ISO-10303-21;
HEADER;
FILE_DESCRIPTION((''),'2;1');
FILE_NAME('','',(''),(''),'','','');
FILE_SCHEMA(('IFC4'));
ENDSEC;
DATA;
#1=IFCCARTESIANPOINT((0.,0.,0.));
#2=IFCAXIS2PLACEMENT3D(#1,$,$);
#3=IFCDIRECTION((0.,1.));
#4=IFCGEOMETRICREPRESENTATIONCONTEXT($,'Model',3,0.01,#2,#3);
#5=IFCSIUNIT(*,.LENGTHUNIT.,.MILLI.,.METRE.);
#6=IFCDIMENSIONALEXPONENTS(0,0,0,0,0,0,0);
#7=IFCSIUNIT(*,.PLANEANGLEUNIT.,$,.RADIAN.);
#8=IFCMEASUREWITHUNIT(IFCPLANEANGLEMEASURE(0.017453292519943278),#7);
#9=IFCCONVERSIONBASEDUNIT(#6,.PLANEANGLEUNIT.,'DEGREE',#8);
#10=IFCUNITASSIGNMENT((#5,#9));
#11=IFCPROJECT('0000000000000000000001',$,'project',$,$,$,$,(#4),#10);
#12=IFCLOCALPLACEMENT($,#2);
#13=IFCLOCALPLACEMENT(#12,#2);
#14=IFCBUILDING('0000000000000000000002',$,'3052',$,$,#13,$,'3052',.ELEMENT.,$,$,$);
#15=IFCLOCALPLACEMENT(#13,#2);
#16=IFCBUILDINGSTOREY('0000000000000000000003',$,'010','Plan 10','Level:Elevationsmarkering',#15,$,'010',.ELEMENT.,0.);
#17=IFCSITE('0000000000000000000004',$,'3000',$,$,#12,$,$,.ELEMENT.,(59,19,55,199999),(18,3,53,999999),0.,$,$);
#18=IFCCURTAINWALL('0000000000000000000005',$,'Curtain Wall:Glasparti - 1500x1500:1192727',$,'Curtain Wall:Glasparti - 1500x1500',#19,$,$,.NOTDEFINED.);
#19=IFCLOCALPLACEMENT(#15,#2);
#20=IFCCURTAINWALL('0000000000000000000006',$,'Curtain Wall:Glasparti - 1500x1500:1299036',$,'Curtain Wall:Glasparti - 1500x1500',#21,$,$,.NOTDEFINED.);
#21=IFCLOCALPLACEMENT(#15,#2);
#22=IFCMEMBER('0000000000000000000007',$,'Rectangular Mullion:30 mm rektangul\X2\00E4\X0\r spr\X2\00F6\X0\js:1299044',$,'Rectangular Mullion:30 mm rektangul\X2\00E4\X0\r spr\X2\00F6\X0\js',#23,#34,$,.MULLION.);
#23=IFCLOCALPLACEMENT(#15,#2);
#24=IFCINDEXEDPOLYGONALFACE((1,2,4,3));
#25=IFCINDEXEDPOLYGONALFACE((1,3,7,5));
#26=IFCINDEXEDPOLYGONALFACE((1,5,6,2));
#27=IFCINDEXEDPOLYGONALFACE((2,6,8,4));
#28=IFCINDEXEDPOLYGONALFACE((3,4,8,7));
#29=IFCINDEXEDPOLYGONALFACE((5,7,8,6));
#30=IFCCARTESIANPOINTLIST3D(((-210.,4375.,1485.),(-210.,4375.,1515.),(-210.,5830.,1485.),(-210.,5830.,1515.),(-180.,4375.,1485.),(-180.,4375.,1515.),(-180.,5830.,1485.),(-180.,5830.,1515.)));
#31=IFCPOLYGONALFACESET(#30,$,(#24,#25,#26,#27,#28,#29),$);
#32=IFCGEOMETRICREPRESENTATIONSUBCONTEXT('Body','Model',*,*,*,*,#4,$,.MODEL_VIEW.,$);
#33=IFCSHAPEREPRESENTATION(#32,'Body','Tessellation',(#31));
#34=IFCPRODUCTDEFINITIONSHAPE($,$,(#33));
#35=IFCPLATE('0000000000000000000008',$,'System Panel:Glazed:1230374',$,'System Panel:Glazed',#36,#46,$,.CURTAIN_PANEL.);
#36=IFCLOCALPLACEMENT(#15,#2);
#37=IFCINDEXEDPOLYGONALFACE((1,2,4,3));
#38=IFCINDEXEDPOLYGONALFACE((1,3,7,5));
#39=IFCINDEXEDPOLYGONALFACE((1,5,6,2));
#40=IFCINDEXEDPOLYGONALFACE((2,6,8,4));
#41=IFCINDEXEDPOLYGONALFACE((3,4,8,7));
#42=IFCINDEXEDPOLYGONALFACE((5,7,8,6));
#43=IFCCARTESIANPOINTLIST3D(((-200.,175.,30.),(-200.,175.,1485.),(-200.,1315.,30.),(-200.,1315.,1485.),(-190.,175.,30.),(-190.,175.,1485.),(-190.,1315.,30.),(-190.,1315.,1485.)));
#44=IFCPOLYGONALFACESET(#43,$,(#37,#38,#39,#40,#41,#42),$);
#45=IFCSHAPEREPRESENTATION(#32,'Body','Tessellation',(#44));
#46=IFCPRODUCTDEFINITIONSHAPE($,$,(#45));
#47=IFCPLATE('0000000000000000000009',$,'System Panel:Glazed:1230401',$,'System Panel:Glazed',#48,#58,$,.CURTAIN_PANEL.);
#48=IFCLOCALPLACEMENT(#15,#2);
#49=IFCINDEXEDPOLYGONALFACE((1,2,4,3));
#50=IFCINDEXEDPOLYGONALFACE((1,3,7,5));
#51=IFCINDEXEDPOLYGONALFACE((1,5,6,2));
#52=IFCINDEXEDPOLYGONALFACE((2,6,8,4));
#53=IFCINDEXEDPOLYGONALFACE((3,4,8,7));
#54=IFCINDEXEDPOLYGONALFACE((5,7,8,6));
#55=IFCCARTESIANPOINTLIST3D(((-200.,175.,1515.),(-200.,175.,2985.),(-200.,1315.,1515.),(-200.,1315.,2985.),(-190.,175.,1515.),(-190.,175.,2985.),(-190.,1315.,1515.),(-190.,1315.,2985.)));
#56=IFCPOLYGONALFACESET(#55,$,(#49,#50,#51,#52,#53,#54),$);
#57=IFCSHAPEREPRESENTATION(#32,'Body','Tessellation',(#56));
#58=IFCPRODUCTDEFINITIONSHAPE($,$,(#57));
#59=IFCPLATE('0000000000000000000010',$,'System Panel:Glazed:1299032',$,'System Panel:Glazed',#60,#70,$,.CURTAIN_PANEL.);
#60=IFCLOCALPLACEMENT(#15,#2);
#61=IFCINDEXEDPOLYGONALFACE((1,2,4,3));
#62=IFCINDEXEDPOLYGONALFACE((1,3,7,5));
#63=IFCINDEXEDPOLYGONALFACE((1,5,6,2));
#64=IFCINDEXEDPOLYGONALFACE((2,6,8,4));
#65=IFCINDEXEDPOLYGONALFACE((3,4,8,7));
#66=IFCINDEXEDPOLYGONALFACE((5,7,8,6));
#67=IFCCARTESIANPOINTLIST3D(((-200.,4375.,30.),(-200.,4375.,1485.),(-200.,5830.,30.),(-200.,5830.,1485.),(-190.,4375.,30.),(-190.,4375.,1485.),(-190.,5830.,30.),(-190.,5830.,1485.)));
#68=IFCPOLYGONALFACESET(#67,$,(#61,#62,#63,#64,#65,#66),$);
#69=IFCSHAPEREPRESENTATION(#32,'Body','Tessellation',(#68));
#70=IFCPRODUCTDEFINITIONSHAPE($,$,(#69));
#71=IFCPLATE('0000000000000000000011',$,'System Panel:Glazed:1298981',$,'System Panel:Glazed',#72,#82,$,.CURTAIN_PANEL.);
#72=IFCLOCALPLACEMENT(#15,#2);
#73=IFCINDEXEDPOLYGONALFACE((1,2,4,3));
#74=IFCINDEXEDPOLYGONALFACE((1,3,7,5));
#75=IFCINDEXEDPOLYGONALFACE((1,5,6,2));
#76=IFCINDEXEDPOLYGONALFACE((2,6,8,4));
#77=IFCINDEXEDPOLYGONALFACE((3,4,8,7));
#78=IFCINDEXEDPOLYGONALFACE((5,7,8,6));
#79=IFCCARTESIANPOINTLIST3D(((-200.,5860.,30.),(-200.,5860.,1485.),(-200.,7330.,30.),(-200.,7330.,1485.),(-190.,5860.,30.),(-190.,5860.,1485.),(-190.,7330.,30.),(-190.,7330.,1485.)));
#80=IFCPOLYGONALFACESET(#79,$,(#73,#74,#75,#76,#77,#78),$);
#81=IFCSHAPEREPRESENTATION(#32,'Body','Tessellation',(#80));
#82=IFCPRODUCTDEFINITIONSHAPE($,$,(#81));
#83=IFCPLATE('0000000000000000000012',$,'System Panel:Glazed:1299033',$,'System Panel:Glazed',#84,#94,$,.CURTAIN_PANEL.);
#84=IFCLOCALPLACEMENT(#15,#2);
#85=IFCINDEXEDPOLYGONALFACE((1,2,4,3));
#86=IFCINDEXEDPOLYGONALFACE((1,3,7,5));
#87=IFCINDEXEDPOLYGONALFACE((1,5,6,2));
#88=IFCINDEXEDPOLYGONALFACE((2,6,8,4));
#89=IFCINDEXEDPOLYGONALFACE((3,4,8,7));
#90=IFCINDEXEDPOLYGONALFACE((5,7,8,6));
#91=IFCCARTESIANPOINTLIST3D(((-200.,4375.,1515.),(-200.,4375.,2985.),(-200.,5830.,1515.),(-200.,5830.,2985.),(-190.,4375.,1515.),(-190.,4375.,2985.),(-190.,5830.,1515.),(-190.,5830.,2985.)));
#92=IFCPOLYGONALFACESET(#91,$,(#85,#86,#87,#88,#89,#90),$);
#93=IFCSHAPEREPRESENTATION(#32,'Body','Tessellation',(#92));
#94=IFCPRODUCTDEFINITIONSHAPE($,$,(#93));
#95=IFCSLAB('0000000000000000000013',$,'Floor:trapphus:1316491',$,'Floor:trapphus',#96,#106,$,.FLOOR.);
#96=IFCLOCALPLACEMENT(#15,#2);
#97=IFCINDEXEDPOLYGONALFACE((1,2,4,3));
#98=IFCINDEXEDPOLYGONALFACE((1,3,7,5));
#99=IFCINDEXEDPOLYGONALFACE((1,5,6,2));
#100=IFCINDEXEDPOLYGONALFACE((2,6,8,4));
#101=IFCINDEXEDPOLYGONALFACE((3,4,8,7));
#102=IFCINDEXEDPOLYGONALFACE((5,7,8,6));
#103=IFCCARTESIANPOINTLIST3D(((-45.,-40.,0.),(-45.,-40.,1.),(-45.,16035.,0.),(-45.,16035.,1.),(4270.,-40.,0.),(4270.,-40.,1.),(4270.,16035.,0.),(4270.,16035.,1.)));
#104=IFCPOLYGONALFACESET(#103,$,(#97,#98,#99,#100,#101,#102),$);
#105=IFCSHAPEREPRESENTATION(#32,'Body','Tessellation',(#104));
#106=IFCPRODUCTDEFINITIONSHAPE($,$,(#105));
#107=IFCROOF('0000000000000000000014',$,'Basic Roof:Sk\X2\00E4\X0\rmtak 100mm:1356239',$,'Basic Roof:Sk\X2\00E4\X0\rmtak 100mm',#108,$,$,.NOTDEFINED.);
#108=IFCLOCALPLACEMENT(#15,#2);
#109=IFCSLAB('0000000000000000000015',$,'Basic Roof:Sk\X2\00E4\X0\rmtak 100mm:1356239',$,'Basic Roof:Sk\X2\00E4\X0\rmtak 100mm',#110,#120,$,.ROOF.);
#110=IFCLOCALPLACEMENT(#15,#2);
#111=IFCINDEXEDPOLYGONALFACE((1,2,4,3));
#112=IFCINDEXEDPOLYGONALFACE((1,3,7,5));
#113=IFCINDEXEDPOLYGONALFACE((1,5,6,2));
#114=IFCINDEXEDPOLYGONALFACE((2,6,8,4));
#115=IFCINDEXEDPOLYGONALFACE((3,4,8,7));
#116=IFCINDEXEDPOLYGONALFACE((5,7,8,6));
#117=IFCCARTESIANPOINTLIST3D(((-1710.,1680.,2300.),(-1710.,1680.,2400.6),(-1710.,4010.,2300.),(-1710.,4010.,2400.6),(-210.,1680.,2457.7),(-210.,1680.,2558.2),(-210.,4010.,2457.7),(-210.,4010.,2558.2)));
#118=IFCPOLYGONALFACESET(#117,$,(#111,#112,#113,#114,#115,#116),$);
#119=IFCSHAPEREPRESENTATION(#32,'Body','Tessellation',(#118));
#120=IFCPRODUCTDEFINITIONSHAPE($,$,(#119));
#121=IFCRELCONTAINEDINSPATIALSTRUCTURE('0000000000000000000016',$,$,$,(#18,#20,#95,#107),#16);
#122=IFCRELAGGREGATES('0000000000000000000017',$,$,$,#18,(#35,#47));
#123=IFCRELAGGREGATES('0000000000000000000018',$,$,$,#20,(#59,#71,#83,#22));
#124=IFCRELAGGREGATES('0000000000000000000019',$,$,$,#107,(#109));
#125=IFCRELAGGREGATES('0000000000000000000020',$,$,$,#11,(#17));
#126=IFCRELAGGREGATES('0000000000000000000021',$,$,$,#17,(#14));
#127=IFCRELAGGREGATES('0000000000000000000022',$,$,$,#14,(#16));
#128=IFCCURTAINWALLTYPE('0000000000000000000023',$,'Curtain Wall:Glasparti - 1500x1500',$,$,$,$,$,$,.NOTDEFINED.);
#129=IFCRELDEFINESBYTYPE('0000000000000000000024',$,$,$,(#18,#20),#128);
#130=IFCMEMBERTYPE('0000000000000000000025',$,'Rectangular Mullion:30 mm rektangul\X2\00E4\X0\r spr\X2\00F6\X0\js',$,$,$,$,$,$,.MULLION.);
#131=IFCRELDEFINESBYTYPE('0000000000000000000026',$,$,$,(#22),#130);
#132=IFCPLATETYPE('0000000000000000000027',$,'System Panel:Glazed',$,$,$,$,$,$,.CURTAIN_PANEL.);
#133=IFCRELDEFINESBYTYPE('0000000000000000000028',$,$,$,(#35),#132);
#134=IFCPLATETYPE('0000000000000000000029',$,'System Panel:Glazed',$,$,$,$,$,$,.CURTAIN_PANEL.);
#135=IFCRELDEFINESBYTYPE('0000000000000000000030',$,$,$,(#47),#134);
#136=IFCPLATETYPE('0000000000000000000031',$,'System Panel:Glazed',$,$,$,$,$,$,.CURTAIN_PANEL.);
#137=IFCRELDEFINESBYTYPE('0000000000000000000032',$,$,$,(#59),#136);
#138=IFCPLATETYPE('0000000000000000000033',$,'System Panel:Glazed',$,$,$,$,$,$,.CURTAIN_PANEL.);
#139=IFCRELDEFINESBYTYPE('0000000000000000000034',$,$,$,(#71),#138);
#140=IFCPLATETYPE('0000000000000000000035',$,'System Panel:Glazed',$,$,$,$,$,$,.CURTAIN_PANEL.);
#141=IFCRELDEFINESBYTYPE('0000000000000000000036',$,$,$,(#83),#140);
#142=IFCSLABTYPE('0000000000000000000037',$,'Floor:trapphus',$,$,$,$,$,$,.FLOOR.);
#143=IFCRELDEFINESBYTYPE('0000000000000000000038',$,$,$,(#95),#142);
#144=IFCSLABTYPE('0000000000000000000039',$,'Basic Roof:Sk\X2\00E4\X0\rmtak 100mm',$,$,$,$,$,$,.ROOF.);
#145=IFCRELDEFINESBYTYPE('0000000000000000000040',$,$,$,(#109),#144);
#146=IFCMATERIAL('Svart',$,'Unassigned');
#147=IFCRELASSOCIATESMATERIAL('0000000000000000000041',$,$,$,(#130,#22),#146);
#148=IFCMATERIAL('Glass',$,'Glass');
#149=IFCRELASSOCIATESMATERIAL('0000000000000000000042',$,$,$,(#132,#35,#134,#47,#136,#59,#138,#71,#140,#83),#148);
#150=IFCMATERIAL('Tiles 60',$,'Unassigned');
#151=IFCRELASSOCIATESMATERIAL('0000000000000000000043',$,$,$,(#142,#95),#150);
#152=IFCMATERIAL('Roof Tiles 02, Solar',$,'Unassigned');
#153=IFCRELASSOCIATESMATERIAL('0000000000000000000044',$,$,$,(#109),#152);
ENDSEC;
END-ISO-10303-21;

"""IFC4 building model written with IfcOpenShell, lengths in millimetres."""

from ifc_helpers import new_model, entity, si_unit, converted_unit, direction, frame, origin, place, context, subcontext, project, spatial, indexed_curve, outline, extrude, source, transform, mapped, material, type_object, type_shapes, element, aggregate, save


model = new_model("IFC4")

# Units and contexts
model_context = context("Model", 3, precision=0.01, world=origin(), true_north=direction((0.0, 1.0)))
body_context = subcontext(model_context, "Body", "Model", "MODEL_VIEW")
ifc_project = project(units=[si_unit("LENGTHUNIT", "METRE", prefix="MILLI"), converted_unit("PLANEANGLEUNIT", "DEGREE", entity("IfcPlaneAngleMeasure", 0.017453292519943278), si_unit("PLANEANGLEUNIT", "RADIAN"), dimensions=[0, 0, 0, 0, 0, 0, 0])], contexts=[model_context])

# Site, building, storey
site_placement = place(None, origin())
site = spatial("IfcSite", under=ifc_project, at=site_placement, Name="3000", CompositionType="ELEMENT", RefLatitude=(59, 19, 55, 199999), RefLongitude=(18, 3, 53, 999999), RefElevation=0.0)
building_placement = place(site_placement, origin())
building = spatial("IfcBuilding", under=site, at=building_placement, Name="3052", LongName="3052", CompositionType="ELEMENT")
storey_placement = place(building_placement, origin())
storey = spatial("IfcBuildingStorey", under=building, at=storey_placement, Name="010", Description="Plan 10", ObjectType="Level:Elevationsmarkering", LongName="010", CompositionType="ELEMENT", Elevation=0.0)

# Curtain wall
curtain_wall_type = type_object("IfcCurtainWallType", Name="Curtain Wall:Glasparti - 1500x1500", PredefinedType="NOTDEFINED")
curtain_wall_1_placement = place(storey_placement, origin())
curtain_wall_1 = element("IfcCurtainWall", 1, at=curtain_wall_1_placement, inside=storey, type_object=curtain_wall_type, Name="Curtain Wall:Glasparti - 1500x1500:1192727", ObjectType="Curtain Wall:Glasparti - 1500x1500", PredefinedType="NOTDEFINED")
ifc_material_1 = material(Name="Svart", Category="Unassigned")

# Curtain wall
curtain_wall_2_placement = place(storey_placement, origin())
curtain_wall_2 = element("IfcCurtainWall", 2, at=curtain_wall_2_placement, inside=storey, type_object=curtain_wall_type, Name="Curtain Wall:Glasparti - 1500x1500:1299036", ObjectType="Curtain Wall:Glasparti - 1500x1500", PredefinedType="NOTDEFINED")

# Member
member_type_1 = type_object("IfcMemberType", Name="Rectangular Mullion:30 mm rektangulär spröjs", PredefinedType="MULLION", material=ifc_material_1)
shared_shape_1 = source(origin(), body_context, "Body", "SweptSolid", [
    extrude(outline(indexed_curve([(-15.0, -15.0), (15.0, -15.0), (15.0, 15.0), (-15.0, 15.0), (-15.0, -15.0)], self_intersect=False)), frame((0.0, 0.0, -1455.0), z_axis=(0.0, 0.0, 1.0), x_axis=(-1.0, 0.0, 0.0)), (0.0, 0.0, 1.0), 1455.0),
])
type_shapes(member_type_1, [shared_shape_1])
member_1_placement = place(curtain_wall_2_placement, frame((-195.0, 5830.0, 1500.0), z_axis=(0.0, 1.0, 0.0), x_axis=(0.0, 0.0, 1.0)))
member_1 = element("IfcMember", 3, at=member_1_placement, type_object=member_type_1, material=ifc_material_1, Name="Rectangular Mullion:30 mm rektangulär spröjs:1299044", ObjectType="Rectangular Mullion:30 mm rektangulär spröjs", PredefinedType="MULLION", context=body_context, shape_type="MappedRepresentation", body=[
    mapped(shared_shape_1, transform((0.0, 0.0, 0.0), scale=1.0)),
])

# Plates
ifc_material_2 = material(Name="Glass", Category="Glass")
plate_type_1 = type_object("IfcPlateType", Name="System Panel:Glazed", PredefinedType="CURTAIN_PANEL", material=ifc_material_2)
shared_shape_2 = source(origin(), body_context, "Body", "SweptSolid", [
    extrude(outline(indexed_curve([(-5.0, -570.0), (5.0, -570.0), (5.0, 570.0), (-5.0, 570.0), (-5.0, -570.0)], self_intersect=False)), frame((0.0, 0.0, 0.0), z_axis=(0.0, 0.0, 1.0), x_axis=(0.0, 1.0, 0.0)), (0.0, 0.0, 1.0), 1455.0),
])
type_shapes(plate_type_1, [shared_shape_2])
plate_1_placement = place(curtain_wall_1_placement, frame((-195.0, 745.0, 30.0), z_axis=(0.0, 0.0, 1.0), x_axis=(0.0, 1.0, 0.0)))
plate_1 = element("IfcPlate", 4, at=plate_1_placement, type_object=plate_type_1, material=ifc_material_2, Name="System Panel:Glazed:1230374", ObjectType="System Panel:Glazed", PredefinedType="CURTAIN_PANEL", context=body_context, shape_type="MappedRepresentation", body=[
    mapped(shared_shape_2, transform((0.0, 0.0, 0.0), scale=1.0)),
])
plate_type_2 = type_object("IfcPlateType", Name="System Panel:Glazed", PredefinedType="CURTAIN_PANEL", material=ifc_material_2)
shared_shape_3 = source(origin(), body_context, "Body", "SweptSolid", [
    extrude(outline(indexed_curve([(-5.0, -570.0), (5.0, -570.0), (5.0, 570.0), (-5.0, 570.0), (-5.0, -570.0)], self_intersect=False)), frame((0.0, 0.0, 0.0), z_axis=(0.0, 0.0, 1.0), x_axis=(0.0, 1.0, 0.0)), (0.0, 0.0, 1.0), 1470.0),
])
type_shapes(plate_type_2, [shared_shape_3])
plate_2_placement = place(curtain_wall_1_placement, frame((-195.0, 745.0, 1515.0), z_axis=(0.0, 0.0, 1.0), x_axis=(0.0, 1.0, 0.0)))
plate_2 = element("IfcPlate", 5, at=plate_2_placement, type_object=plate_type_2, material=ifc_material_2, Name="System Panel:Glazed:1230401", ObjectType="System Panel:Glazed", PredefinedType="CURTAIN_PANEL", context=body_context, shape_type="MappedRepresentation", body=[
    mapped(shared_shape_3, transform((0.0, 0.0, 0.0), scale=1.0)),
])
aggregate(curtain_wall_1, [plate_1, plate_2])
plate_type_3 = type_object("IfcPlateType", Name="System Panel:Glazed", PredefinedType="CURTAIN_PANEL", material=ifc_material_2)
shared_shape_4 = source(origin(), body_context, "Body", "SweptSolid", [
    extrude(outline(indexed_curve([(-5.0, -727.5), (5.0, -727.5), (5.0, 727.5), (-5.0, 727.5), (-5.0, -727.5)], self_intersect=False)), frame((0.0, 0.0, 0.0), z_axis=(0.0, 0.0, 1.0), x_axis=(0.0, 1.0, 0.0)), (0.0, 0.0, 1.0), 1455.0),
])
type_shapes(plate_type_3, [shared_shape_4])
plate_3_placement = place(curtain_wall_2_placement, frame((-195.0, 5102.5, 30.0), z_axis=(0.0, 0.0, 1.0), x_axis=(0.0, 1.0, 0.0)))
plate_3 = element("IfcPlate", 6, at=plate_3_placement, type_object=plate_type_3, material=ifc_material_2, Name="System Panel:Glazed:1299032", ObjectType="System Panel:Glazed", PredefinedType="CURTAIN_PANEL", context=body_context, shape_type="MappedRepresentation", body=[
    mapped(shared_shape_4, transform((0.0, 0.0, 0.0), scale=1.0)),
])
plate_type_4 = type_object("IfcPlateType", Name="System Panel:Glazed", PredefinedType="CURTAIN_PANEL", material=ifc_material_2)
shared_shape_5 = source(origin(), body_context, "Body", "SweptSolid", [
    extrude(outline(indexed_curve([(-5.0, -735.0), (5.0, -735.0), (5.0, 735.0), (-5.0, 735.0), (-5.0, -735.0)], self_intersect=False)), frame((0.0, 0.0, 0.0), z_axis=(0.0, 0.0, 1.0), x_axis=(0.0, 1.0, 0.0)), (0.0, 0.0, 1.0), 1455.0),
])
type_shapes(plate_type_4, [shared_shape_5])
plate_4_placement = place(curtain_wall_2_placement, frame((-195.0, 6595.0, 30.0), z_axis=(0.0, 0.0, 1.0), x_axis=(0.0, 1.0, 0.0)))
plate_4 = element("IfcPlate", 7, at=plate_4_placement, type_object=plate_type_4, material=ifc_material_2, Name="System Panel:Glazed:1298981", ObjectType="System Panel:Glazed", PredefinedType="CURTAIN_PANEL", context=body_context, shape_type="MappedRepresentation", body=[
    mapped(shared_shape_5, transform((0.0, 0.0, 0.0), scale=1.0)),
])
plate_type_5 = type_object("IfcPlateType", Name="System Panel:Glazed", PredefinedType="CURTAIN_PANEL", material=ifc_material_2)
shared_shape_6 = source(origin(), body_context, "Body", "SweptSolid", [
    extrude(outline(indexed_curve([(-5.0, -727.5), (5.0, -727.5), (5.0, 727.5), (-5.0, 727.5), (-5.0, -727.5)], self_intersect=False)), frame((0.0, 0.0, 0.0), z_axis=(0.0, 0.0, 1.0), x_axis=(0.0, 1.0, 0.0)), (0.0, 0.0, 1.0), 1470.0),
])
type_shapes(plate_type_5, [shared_shape_6])
plate_5_placement = place(curtain_wall_2_placement, frame((-195.0, 5102.5, 1515.0), z_axis=(0.0, 0.0, 1.0), x_axis=(0.0, 1.0, 0.0)))
plate_5 = element("IfcPlate", 8, at=plate_5_placement, type_object=plate_type_5, material=ifc_material_2, Name="System Panel:Glazed:1299033", ObjectType="System Panel:Glazed", PredefinedType="CURTAIN_PANEL", context=body_context, shape_type="MappedRepresentation", body=[
    mapped(shared_shape_6, transform((0.0, 0.0, 0.0), scale=1.0)),
])
aggregate(curtain_wall_2, [plate_3, plate_4, plate_5, member_1])

# Slab
ifc_material_3 = material(Name="Tiles 60", Category="Unassigned")
slab_type_1 = type_object("IfcSlabType", Name="Floor:trapphus", PredefinedType="FLOOR", material=ifc_material_3)
slab_1_placement = place(storey_placement, origin())
element("IfcSlab", 9, at=slab_1_placement, inside=storey, type_object=slab_type_1, material=ifc_material_3, Name="Floor:trapphus:1316491", ObjectType="Floor:trapphus", PredefinedType="FLOOR", context=body_context, shape_type="SweptSolid", body=[
    extrude(outline(indexed_curve([(-8037.5, -2157.5), (8037.5, -2157.5), (8037.5, 2157.5), (-8037.5, 2157.5), (-8037.5, -2157.5)], self_intersect=False)), frame((2112.5, 7997.5, 1.0), z_axis=(0.0, 0.0, -1.0), x_axis=(0.0, 1.0, 0.0)), (0.0, 0.0, 1.0), 1.0),
])

# Roof, slab
roof_placement = place(storey_placement, frame((-1710.0, 1680.0, 2300.0)))
roof = element("IfcRoof", 10, at=roof_placement, inside=storey, Name="Basic Roof:Skärmtak 100mm:1356239", ObjectType="Basic Roof:Skärmtak 100mm", PredefinedType="NOTDEFINED")
ifc_material_4 = material(Name="Roof Tiles 02, Solar", Category="Unassigned")
slab_type_2 = type_object("IfcSlabType", Name="Basic Roof:Skärmtak 100mm", PredefinedType="ROOF")
slab_2_placement = place(roof_placement, origin())
slab_2 = element("IfcSlab", 11, at=slab_2_placement, type_object=slab_type_2, material=ifc_material_4, Name="Basic Roof:Skärmtak 100mm:1356239", ObjectType="Basic Roof:Skärmtak 100mm", PredefinedType="ROOF", context=body_context, shape_type="SweptSolid", body=[
    extrude(outline(indexed_curve([(-754.1, 1165.0), (-754.1, -1165.0), (754.1, -1165.0), (754.1, 1165.0), (-754.1, 1165.0)], self_intersect=False)), frame((750.0, 1165.0, 78.8), z_axis=(-0.104528, 0.0, 0.994522), x_axis=(0.994522, 0.0, 0.104528)), (0.104528, 0.0, 0.994522), 100.6),
])
aggregate(roof, [slab_2])

save(model, "model.ifc")
